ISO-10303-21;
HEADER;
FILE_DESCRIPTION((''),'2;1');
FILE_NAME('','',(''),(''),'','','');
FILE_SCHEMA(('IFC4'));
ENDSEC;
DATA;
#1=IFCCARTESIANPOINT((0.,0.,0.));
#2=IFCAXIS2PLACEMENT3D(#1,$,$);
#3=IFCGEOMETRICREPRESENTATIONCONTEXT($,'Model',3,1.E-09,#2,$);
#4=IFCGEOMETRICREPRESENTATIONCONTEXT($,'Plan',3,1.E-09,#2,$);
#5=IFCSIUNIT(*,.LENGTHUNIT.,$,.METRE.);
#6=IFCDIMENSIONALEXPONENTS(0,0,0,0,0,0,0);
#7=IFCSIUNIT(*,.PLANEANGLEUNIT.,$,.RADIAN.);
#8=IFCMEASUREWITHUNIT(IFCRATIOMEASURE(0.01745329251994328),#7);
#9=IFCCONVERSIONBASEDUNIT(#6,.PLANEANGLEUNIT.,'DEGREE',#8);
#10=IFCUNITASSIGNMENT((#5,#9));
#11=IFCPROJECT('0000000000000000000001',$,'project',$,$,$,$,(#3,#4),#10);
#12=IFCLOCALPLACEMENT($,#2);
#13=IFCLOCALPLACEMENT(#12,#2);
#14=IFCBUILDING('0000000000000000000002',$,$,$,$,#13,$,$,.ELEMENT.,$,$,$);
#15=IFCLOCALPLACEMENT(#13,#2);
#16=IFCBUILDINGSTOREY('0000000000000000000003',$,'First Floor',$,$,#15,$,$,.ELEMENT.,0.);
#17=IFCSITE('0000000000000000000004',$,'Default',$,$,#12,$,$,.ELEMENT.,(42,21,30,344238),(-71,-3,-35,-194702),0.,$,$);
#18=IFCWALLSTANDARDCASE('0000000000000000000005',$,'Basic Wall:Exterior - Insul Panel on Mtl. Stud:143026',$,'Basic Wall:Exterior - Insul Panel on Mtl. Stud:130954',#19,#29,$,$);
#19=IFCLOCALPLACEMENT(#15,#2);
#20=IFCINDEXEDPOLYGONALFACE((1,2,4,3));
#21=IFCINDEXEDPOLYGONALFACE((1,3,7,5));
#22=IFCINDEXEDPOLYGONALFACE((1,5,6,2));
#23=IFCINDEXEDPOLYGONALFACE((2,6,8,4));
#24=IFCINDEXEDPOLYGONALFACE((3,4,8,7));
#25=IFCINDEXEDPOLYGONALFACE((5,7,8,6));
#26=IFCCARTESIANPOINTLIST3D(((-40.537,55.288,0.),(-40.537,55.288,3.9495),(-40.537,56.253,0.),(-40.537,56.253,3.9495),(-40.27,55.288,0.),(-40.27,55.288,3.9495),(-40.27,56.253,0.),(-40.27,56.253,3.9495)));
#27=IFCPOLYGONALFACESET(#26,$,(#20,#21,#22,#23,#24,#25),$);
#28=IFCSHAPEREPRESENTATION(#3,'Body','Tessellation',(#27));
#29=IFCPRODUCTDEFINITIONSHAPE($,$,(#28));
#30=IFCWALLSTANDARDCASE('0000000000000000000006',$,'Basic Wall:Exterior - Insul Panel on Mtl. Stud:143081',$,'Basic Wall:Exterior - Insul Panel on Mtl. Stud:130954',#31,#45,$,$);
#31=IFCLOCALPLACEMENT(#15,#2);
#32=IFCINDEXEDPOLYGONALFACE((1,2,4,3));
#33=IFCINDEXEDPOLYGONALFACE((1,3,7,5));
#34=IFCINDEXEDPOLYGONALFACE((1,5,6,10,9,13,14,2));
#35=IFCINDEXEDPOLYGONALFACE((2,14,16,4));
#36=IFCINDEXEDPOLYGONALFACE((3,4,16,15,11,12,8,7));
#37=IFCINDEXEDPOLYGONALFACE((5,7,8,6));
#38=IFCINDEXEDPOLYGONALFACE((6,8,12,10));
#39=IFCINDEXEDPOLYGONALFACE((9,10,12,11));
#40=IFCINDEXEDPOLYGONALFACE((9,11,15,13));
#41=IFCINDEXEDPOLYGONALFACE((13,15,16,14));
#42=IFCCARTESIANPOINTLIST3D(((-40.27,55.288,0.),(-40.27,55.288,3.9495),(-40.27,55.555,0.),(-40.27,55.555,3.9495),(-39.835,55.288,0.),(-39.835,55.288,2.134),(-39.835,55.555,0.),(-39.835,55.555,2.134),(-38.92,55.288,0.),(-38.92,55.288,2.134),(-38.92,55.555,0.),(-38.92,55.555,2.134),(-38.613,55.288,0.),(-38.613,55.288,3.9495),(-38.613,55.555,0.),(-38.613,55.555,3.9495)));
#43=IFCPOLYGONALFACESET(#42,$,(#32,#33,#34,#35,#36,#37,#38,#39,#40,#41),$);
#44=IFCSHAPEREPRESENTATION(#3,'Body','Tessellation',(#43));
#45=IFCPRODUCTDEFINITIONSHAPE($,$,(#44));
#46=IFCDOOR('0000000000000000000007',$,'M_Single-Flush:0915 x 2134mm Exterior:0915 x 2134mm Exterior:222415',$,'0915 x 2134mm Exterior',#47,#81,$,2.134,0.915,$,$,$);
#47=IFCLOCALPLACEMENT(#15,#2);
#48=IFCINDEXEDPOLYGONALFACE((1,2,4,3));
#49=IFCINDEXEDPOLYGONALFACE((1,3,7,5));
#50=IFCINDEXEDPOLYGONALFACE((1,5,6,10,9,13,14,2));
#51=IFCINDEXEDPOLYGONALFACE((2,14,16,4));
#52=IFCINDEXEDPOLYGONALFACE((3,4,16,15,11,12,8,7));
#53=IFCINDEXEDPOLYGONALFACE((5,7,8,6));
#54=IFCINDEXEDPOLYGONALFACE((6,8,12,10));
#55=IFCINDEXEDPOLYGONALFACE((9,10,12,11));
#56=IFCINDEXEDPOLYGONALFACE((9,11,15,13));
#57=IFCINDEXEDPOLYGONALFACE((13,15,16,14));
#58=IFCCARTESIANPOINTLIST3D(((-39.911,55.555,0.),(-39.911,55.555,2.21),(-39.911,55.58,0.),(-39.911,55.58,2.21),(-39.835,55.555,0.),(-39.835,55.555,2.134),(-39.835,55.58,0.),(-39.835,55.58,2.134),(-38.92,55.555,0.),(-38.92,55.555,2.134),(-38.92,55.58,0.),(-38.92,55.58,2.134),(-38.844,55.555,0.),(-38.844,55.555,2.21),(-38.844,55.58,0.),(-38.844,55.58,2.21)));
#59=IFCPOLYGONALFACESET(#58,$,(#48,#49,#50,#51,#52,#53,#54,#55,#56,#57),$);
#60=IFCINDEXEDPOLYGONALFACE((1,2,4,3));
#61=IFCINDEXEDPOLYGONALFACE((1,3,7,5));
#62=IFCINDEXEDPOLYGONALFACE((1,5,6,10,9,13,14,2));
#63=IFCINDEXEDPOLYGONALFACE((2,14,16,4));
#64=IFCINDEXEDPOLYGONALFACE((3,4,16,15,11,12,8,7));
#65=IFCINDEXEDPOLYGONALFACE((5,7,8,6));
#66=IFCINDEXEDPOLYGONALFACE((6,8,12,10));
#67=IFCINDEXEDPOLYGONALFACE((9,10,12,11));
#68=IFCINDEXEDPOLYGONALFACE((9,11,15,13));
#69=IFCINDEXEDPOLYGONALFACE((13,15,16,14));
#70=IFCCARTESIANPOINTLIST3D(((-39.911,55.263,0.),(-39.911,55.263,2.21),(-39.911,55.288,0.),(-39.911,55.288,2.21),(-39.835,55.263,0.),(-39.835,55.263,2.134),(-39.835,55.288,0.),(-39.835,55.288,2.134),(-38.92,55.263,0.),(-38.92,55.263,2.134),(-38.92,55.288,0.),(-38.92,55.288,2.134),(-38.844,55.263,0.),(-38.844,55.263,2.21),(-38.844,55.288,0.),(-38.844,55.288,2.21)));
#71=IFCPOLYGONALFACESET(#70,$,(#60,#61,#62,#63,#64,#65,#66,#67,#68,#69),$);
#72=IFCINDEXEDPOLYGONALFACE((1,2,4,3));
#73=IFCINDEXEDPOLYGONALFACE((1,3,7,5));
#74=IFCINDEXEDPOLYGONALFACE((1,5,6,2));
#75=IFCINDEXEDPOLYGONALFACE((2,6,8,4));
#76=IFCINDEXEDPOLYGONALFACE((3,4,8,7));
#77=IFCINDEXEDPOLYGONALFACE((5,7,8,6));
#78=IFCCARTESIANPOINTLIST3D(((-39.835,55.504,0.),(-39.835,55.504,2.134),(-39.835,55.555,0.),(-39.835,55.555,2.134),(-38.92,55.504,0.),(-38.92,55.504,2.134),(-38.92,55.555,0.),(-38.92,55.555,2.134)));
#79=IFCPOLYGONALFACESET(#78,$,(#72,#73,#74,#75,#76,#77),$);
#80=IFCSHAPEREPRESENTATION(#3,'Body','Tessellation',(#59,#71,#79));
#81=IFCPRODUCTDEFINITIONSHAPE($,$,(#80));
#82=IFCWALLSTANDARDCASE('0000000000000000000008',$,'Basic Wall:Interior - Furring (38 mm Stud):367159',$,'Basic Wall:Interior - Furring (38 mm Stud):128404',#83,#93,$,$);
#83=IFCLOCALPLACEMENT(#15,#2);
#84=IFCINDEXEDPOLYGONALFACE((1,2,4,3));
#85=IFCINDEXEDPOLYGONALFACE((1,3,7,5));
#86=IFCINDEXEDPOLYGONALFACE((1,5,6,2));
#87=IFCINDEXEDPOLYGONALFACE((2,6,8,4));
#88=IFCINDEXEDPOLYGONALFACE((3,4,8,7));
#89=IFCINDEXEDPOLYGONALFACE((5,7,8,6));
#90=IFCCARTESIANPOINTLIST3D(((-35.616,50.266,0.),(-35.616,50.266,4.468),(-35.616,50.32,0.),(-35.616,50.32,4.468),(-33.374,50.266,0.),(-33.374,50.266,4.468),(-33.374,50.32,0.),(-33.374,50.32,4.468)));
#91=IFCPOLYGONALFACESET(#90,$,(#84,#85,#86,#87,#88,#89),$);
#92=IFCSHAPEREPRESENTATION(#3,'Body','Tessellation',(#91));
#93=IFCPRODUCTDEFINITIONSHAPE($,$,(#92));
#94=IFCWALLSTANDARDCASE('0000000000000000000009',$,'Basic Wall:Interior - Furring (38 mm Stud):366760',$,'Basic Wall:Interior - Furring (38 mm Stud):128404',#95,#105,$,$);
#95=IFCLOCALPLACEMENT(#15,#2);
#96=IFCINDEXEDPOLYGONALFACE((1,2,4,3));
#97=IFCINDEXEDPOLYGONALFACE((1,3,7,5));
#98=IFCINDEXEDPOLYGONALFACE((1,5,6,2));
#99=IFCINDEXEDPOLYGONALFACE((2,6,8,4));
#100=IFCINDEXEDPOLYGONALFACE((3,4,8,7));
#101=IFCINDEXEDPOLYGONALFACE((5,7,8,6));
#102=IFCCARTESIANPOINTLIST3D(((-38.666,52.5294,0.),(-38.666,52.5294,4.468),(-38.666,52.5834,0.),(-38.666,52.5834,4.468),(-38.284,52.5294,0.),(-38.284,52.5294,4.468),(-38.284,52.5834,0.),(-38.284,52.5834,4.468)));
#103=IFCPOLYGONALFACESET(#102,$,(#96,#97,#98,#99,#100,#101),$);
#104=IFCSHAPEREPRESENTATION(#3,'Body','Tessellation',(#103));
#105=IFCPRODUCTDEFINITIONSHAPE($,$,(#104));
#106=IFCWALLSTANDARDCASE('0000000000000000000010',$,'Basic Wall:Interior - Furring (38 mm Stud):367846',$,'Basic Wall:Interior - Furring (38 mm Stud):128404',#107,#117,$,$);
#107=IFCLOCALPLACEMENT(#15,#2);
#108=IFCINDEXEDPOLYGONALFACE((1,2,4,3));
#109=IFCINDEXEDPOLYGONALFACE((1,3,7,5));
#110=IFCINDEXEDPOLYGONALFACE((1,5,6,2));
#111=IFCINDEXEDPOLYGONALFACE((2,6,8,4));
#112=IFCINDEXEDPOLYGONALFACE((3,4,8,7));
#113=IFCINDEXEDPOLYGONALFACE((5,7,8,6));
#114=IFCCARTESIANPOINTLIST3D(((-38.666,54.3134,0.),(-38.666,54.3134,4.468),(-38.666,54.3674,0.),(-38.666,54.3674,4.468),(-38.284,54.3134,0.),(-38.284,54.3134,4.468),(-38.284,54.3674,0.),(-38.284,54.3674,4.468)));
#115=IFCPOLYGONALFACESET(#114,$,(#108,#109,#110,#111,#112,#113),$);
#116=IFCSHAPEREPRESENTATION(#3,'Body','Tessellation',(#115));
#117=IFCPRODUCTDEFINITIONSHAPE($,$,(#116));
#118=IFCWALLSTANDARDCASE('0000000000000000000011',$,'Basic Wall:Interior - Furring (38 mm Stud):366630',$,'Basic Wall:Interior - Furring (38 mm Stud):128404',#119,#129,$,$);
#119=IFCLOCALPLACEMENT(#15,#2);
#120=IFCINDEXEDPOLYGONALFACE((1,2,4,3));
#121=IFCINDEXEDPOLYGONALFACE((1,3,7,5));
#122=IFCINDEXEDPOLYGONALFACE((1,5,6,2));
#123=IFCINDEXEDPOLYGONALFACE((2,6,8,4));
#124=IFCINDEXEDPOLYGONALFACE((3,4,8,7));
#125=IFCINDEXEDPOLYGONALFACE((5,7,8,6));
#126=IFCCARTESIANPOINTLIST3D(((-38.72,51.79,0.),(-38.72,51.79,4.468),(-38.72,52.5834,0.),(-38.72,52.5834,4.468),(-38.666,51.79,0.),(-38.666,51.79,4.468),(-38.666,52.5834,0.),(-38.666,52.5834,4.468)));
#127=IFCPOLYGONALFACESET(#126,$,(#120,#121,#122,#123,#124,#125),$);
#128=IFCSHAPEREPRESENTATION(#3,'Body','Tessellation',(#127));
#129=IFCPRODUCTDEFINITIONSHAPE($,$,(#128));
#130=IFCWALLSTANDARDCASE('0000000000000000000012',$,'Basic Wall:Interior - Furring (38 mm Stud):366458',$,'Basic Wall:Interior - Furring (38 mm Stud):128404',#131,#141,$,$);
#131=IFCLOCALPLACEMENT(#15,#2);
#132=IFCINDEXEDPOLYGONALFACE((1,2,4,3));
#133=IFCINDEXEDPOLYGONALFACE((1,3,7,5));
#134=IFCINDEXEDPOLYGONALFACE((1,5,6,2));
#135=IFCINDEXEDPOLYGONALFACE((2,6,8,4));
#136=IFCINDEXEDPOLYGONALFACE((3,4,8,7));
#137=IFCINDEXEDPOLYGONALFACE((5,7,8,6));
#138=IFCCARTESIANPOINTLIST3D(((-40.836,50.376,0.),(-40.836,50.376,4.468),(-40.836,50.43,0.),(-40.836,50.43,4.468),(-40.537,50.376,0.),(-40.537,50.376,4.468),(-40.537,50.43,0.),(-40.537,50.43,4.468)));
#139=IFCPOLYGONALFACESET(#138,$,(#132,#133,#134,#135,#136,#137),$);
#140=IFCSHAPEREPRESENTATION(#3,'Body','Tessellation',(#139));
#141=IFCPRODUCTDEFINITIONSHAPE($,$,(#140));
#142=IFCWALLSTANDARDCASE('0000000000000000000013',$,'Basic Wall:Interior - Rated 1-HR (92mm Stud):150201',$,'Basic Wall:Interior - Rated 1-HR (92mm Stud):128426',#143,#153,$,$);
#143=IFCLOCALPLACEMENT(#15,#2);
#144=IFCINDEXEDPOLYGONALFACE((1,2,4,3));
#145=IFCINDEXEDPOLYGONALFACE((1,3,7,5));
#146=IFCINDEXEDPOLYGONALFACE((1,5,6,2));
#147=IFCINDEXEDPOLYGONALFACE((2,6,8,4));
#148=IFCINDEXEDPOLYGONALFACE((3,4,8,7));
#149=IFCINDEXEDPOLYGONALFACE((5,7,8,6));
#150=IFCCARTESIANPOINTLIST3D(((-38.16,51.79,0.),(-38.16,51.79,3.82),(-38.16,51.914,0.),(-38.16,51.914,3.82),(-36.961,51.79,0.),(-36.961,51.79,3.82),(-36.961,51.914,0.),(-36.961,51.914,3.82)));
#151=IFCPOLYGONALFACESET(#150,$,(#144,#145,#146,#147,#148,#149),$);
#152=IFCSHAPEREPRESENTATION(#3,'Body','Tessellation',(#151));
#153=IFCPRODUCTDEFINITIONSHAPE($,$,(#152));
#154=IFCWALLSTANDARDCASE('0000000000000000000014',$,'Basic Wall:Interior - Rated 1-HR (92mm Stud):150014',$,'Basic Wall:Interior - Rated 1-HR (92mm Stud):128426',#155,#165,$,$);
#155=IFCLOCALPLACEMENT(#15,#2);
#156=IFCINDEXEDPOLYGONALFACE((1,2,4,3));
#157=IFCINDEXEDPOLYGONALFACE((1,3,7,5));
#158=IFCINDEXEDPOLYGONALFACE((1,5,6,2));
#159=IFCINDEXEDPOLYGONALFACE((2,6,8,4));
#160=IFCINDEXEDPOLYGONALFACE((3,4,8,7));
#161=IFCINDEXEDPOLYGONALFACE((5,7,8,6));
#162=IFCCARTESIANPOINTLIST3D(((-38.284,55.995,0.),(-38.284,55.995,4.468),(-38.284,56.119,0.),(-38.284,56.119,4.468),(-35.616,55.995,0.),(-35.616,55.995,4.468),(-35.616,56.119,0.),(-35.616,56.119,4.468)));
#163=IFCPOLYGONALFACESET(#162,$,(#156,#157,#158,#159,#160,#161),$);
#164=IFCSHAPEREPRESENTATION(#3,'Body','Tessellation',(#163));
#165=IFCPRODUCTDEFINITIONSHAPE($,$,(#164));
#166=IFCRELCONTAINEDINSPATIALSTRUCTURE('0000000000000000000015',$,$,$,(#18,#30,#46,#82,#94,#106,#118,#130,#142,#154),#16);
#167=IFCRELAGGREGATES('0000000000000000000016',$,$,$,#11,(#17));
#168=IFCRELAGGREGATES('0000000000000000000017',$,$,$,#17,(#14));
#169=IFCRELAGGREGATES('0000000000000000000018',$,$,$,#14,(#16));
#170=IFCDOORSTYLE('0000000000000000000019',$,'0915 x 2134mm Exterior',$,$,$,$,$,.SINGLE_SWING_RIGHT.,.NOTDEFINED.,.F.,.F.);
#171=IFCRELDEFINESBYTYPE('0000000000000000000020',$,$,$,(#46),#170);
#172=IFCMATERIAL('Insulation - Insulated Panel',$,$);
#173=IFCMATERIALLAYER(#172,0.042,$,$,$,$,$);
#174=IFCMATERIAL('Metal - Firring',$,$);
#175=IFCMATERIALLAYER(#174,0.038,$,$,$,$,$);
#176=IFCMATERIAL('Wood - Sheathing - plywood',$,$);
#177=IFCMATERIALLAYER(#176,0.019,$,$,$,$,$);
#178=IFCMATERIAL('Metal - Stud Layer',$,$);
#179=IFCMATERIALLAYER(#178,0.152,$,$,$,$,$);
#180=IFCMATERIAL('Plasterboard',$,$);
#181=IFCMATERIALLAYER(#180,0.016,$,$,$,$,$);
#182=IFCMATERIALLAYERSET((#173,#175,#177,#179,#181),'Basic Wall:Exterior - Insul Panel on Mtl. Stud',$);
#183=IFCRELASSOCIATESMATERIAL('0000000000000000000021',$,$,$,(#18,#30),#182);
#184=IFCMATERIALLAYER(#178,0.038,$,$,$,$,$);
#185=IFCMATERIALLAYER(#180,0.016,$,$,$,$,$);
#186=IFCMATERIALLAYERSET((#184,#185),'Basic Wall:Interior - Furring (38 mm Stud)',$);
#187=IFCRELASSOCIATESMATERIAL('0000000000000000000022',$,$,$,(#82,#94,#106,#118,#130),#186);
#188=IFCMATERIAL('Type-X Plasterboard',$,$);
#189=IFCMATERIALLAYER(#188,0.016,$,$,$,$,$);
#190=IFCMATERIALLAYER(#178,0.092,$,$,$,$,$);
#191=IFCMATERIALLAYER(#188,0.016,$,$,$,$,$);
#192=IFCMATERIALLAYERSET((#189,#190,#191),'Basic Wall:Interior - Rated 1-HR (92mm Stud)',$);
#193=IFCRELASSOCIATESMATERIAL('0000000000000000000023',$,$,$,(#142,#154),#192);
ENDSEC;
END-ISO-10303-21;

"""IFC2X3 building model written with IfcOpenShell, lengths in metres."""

from ifc_helpers import new_model, entity, si_unit, converted_unit, frame, frame_2d, origin, origin_2d_with_axis, place, context, project, spatial, polyline, rectangle, outline, extrude, source, transform, mapped, material, layer, layer_set, layer_usage, type_object, type_shapes, element, fill, save


model = new_model("IFC2X3")

# Units and contexts
model_context = context("Model", 3, precision=1e-09, world=origin())
plan_context = context("Plan", 3, precision=1e-09, world=origin())
ifc_project = project(units=[si_unit("LENGTHUNIT", "METRE"), converted_unit("PLANEANGLEUNIT", "DEGREE", entity("IfcRatioMeasure", 0.01745329251994328), si_unit("PLANEANGLEUNIT", "RADIAN"), dimensions=[0, 0, 0, 0, 0, 0, 0])], contexts=[model_context, plan_context])

# Site, building, storey
site_placement = place(None, origin())
site = spatial("IfcSite", under=ifc_project, at=site_placement, Name="Default", CompositionType="ELEMENT", RefLatitude=(42, 21, 30, 344238), RefLongitude=(-71, -3, -35, -194702), RefElevation=0.0)
building_placement = place(site_placement, origin())
building = spatial("IfcBuilding", under=site, at=building_placement, CompositionType="ELEMENT")
storey_placement = place(building_placement, origin())
storey = spatial("IfcBuildingStorey", under=building, at=storey_placement, Name="First Floor", CompositionType="ELEMENT", Elevation=0.0)

# Shared definitions
ifc_material_1 = material(Name="Insulation - Insulated Panel")
ifc_layer_1 = layer(ifc_material_1, 0.042)
ifc_material_2 = material(Name="Metal - Firring")
ifc_layer_2 = layer(ifc_material_2, 0.038)
ifc_material_3 = material(Name="Wood - Sheathing - plywood")
ifc_layer_3 = layer(ifc_material_3, 0.019)
ifc_material_4 = material(Name="Metal - Stud Layer")
ifc_layer_4 = layer(ifc_material_4, 0.152)
ifc_material_5 = material(Name="Plasterboard")
ifc_layer_5 = layer(ifc_material_5, 0.016)
ifc_layer_set_1 = layer_set([ifc_layer_1, ifc_layer_2, ifc_layer_3, ifc_layer_4, ifc_layer_5], Name="Basic Wall:Exterior - Insul Panel on Mtl. Stud")
ifc_layer_usage_1 = layer_usage(ifc_layer_set_1, "AXIS2", "NEGATIVE", 0.1335)
ifc_material_6 = material(Name="Type-X Plasterboard")
ifc_layer_6 = layer(ifc_material_6, 0.016)
ifc_layer_7 = layer(ifc_material_4, 0.092)
ifc_layer_8 = layer(ifc_material_6, 0.016)
ifc_layer_set_2 = layer_set([ifc_layer_6, ifc_layer_7, ifc_layer_8], Name="Basic Wall:Interior - Rated 1-HR (92mm Stud)")
ifc_layer_usage_2 = layer_usage(ifc_layer_set_2, "AXIS2", "NEGATIVE", 0.062)

# Wall
ifc_layer_9 = layer(ifc_material_4, 0.038)
ifc_layer_10 = layer(ifc_material_5, 0.016)
ifc_layer_set_3 = layer_set([ifc_layer_9, ifc_layer_10], Name="Basic Wall:Interior - Furring (38 mm Stud)")
ifc_layer_usage_3 = layer_usage(ifc_layer_set_3, "AXIS2", "NEGATIVE", 0.027)
wall_1_placement = place(storey_placement, frame((-40.4035, 56.253, 0.0), z_axis=(0.0, 0.0, 1.0), x_axis=(0.0, -1.0, 0.0)))
element("IfcWallStandardCase", 1, at=wall_1_placement, inside=storey, material=ifc_layer_usage_1, Name="Basic Wall:Exterior - Insul Panel on Mtl. Stud:143026", ObjectType="Basic Wall:Exterior - Insul Panel on Mtl. Stud:130954", context=model_context, shape_type="SweptSolid", body=[
    extrude(rectangle(XDim=0.965, YDim=0.267, at=frame_2d((0.4825, 0.0), x_axis=(-1.0, 0.0))), origin(), (0.0, 0.0, 1.0), 3.9495),
])

# Wall, opening, door
wall_2_placement = place(storey_placement, frame((-40.27, 55.4215, 0.0)))
wall_2 = element("IfcWallStandardCase", 2, at=wall_2_placement, inside=storey, material=ifc_layer_usage_1, Name="Basic Wall:Exterior - Insul Panel on Mtl. Stud:143081", ObjectType="Basic Wall:Exterior - Insul Panel on Mtl. Stud:130954", context=model_context, shape_type="SweptSolid", body=[
    extrude(rectangle(XDim=1.657, YDim=0.267, at=frame_2d((0.8285, 0.0), x_axis=(-1.0, 0.0))), origin(), (0.0, 0.0, 1.0), 3.9495),
])
opening_1_placement = place(wall_2_placement, frame((0.435, -0.1335, 0.0)))
opening_1 = element("IfcOpeningElement", 3, at=opening_1_placement, cuts=wall_2, ObjectType="Opening", context=model_context, shape_type="SweptSolid", body=[
    extrude(rectangle(XDim=0.915, YDim=2.134, at=frame_2d((1.067, 0.4575), x_axis=(0.0, 1.0))), frame((0.0, 0.0, 0.0), z_axis=(0.0, 1.0, 0.0), x_axis=(0.0, 0.0, 1.0)), (0.0, 0.0, 1.0), 0.267),
])
door_style_1 = type_object("IfcDoorStyle", Name="0915 x 2134mm Exterior", ConstructionType="NOTDEFINED", OperationType="SINGLE_SWING_RIGHT", ParameterTakesPrecedence=False, Sizeable=False)
shared_shape_1 = source(origin(), model_context, "Body", "SweptSolid", [
    extrude(outline(polyline([(-0.5335, -1.124), (0.5335, -1.124), (0.5335, 1.086), (0.4575, 1.086), (0.4575, -1.048), (-0.4575, -1.048), (-0.4575, 1.086), (-0.5335, 1.086), (-0.5335, -1.124)])), frame((0.4575, 0.267, 1.086), z_axis=(0.0, 1.0, 0.0), x_axis=(1.0, 0.0, 0.0)), (0.0, 0.0, 1.0), 0.025),
    extrude(outline(polyline([(-1.124, -0.5335), (1.086, -0.5335), (1.086, -0.4575), (-1.048, -0.4575), (-1.048, 0.4575), (1.086, 0.4575), (1.086, 0.5335), (-1.124, 0.5335), (-1.124, -0.5335)])), frame((0.4575, -0.025, 1.086), z_axis=(0.0, 1.0, 0.0), x_axis=(0.0, 0.0, -1.0)), (0.0, 0.0, 1.0), 0.025),
    extrude(rectangle(XDim=0.051, YDim=0.915, at=origin_2d_with_axis()), frame((0.4575, 0.2415, 0.0), z_axis=(0.0, 0.0, 1.0), x_axis=(0.0, 1.0, 0.0)), (0.0, 0.0, 1.0), 2.134),
])
type_shapes(door_style_1, [shared_shape_1])
door_1_placement = place(opening_1_placement, origin())
door_1 = element("IfcDoor", 4, at=door_1_placement, inside=storey, type_object=door_style_1, Name="M_Single-Flush:0915 x 2134mm Exterior:0915 x 2134mm Exterior:222415", ObjectType="0915 x 2134mm Exterior", OverallHeight=2.134, OverallWidth=0.915, context=model_context, shape_type="MappedRepresentation", body=[
    mapped(shared_shape_1, transform((0.0, 0.0, 0.0), scale=1.0)),
])
fill(opening_1, door_1)

# Walls
wall_3_placement = place(storey_placement, frame((-33.374, 50.293, 0.0), z_axis=(0.0, 0.0, 1.0), x_axis=(-1.0, 0.0, 0.0)))
element("IfcWallStandardCase", 5, at=wall_3_placement, inside=storey, material=ifc_layer_usage_3, Name="Basic Wall:Interior - Furring (38 mm Stud):367159", ObjectType="Basic Wall:Interior - Furring (38 mm Stud):128404", context=model_context, shape_type="SweptSolid", body=[
    extrude(rectangle(XDim=2.242, YDim=0.054, at=frame_2d((1.121, 0.0), x_axis=(-1.0, 0.0))), origin(), (0.0, 0.0, 1.0), 4.468),
])
wall_4_placement = place(storey_placement, frame((-38.284, 52.5564, 0.0), z_axis=(0.0, 0.0, 1.0), x_axis=(-1.0, 0.0, 0.0)))
element("IfcWallStandardCase", 6, at=wall_4_placement, inside=storey, material=ifc_layer_usage_3, Name="Basic Wall:Interior - Furring (38 mm Stud):366760", ObjectType="Basic Wall:Interior - Furring (38 mm Stud):128404", context=model_context, shape_type="SweptSolid", body=[
    extrude(rectangle(XDim=0.382, YDim=0.054, at=frame_2d((0.191, 0.0), x_axis=(-1.0, 0.0))), origin(), (0.0, 0.0, 1.0), 4.468),
])
wall_5_placement = place(storey_placement, frame((-38.666, 54.3404, 0.0)))
element("IfcWallStandardCase", 7, at=wall_5_placement, inside=storey, material=ifc_layer_usage_3, Name="Basic Wall:Interior - Furring (38 mm Stud):367846", ObjectType="Basic Wall:Interior - Furring (38 mm Stud):128404", context=model_context, shape_type="SweptSolid", body=[
    extrude(rectangle(XDim=0.382, YDim=0.054, at=frame_2d((0.191, 0.0), x_axis=(-1.0, 0.0))), origin(), (0.0, 0.0, 1.0), 4.468),
])
wall_6_placement = place(storey_placement, frame((-38.693, 52.5834, 0.0), z_axis=(0.0, 0.0, 1.0), x_axis=(0.0, -1.0, 0.0)))
element("IfcWallStandardCase", 8, at=wall_6_placement, inside=storey, material=ifc_layer_usage_3, Name="Basic Wall:Interior - Furring (38 mm Stud):366630", ObjectType="Basic Wall:Interior - Furring (38 mm Stud):128404", context=model_context, shape_type="SweptSolid", body=[
    extrude(rectangle(XDim=0.7934, YDim=0.054, at=frame_2d((0.3967, 0.0), x_axis=(-1.0, 0.0))), origin(), (0.0, 0.0, 1.0), 4.468),
])
wall_7_placement = place(storey_placement, frame((-40.537, 50.403, 0.0), z_axis=(0.0, 0.0, 1.0), x_axis=(-1.0, 0.0, 0.0)))
element("IfcWallStandardCase", 9, at=wall_7_placement, inside=storey, material=ifc_layer_usage_3, Name="Basic Wall:Interior - Furring (38 mm Stud):366458", ObjectType="Basic Wall:Interior - Furring (38 mm Stud):128404", context=model_context, shape_type="SweptSolid", body=[
    extrude(rectangle(XDim=0.299, YDim=0.054, at=frame_2d((0.1495, 0.0), x_axis=(-1.0, 0.0))), origin(), (0.0, 0.0, 1.0), 4.468),
])
wall_8_placement = place(storey_placement, frame((-36.961, 51.852, 0.0), z_axis=(0.0, 0.0, 1.0), x_axis=(-1.0, 0.0, 0.0)))
element("IfcWallStandardCase", 10, at=wall_8_placement, inside=storey, material=ifc_layer_usage_2, Name="Basic Wall:Interior - Rated 1-HR (92mm Stud):150201", ObjectType="Basic Wall:Interior - Rated 1-HR (92mm Stud):128426", context=model_context, shape_type="SweptSolid", body=[
    extrude(rectangle(XDim=1.199, YDim=0.124, at=frame_2d((0.5995, 0.0), x_axis=(-1.0, 0.0))), origin(), (0.0, 0.0, 1.0), 3.82),
])
wall_9_placement = place(storey_placement, frame((-35.616, 56.057, 0.0), z_axis=(0.0, 0.0, 1.0), x_axis=(-1.0, 0.0, 0.0)))
element("IfcWallStandardCase", 11, at=wall_9_placement, inside=storey, material=ifc_layer_usage_2, Name="Basic Wall:Interior - Rated 1-HR (92mm Stud):150014", ObjectType="Basic Wall:Interior - Rated 1-HR (92mm Stud):128426", context=model_context, shape_type="SweptSolid", body=[
    extrude(rectangle(XDim=2.668, YDim=0.124, at=frame_2d((1.334, 0.0), x_axis=(-1.0, 0.0))), origin(), (0.0, 0.0, 1.0), 4.468),
])

save(model, "model.ifc")
